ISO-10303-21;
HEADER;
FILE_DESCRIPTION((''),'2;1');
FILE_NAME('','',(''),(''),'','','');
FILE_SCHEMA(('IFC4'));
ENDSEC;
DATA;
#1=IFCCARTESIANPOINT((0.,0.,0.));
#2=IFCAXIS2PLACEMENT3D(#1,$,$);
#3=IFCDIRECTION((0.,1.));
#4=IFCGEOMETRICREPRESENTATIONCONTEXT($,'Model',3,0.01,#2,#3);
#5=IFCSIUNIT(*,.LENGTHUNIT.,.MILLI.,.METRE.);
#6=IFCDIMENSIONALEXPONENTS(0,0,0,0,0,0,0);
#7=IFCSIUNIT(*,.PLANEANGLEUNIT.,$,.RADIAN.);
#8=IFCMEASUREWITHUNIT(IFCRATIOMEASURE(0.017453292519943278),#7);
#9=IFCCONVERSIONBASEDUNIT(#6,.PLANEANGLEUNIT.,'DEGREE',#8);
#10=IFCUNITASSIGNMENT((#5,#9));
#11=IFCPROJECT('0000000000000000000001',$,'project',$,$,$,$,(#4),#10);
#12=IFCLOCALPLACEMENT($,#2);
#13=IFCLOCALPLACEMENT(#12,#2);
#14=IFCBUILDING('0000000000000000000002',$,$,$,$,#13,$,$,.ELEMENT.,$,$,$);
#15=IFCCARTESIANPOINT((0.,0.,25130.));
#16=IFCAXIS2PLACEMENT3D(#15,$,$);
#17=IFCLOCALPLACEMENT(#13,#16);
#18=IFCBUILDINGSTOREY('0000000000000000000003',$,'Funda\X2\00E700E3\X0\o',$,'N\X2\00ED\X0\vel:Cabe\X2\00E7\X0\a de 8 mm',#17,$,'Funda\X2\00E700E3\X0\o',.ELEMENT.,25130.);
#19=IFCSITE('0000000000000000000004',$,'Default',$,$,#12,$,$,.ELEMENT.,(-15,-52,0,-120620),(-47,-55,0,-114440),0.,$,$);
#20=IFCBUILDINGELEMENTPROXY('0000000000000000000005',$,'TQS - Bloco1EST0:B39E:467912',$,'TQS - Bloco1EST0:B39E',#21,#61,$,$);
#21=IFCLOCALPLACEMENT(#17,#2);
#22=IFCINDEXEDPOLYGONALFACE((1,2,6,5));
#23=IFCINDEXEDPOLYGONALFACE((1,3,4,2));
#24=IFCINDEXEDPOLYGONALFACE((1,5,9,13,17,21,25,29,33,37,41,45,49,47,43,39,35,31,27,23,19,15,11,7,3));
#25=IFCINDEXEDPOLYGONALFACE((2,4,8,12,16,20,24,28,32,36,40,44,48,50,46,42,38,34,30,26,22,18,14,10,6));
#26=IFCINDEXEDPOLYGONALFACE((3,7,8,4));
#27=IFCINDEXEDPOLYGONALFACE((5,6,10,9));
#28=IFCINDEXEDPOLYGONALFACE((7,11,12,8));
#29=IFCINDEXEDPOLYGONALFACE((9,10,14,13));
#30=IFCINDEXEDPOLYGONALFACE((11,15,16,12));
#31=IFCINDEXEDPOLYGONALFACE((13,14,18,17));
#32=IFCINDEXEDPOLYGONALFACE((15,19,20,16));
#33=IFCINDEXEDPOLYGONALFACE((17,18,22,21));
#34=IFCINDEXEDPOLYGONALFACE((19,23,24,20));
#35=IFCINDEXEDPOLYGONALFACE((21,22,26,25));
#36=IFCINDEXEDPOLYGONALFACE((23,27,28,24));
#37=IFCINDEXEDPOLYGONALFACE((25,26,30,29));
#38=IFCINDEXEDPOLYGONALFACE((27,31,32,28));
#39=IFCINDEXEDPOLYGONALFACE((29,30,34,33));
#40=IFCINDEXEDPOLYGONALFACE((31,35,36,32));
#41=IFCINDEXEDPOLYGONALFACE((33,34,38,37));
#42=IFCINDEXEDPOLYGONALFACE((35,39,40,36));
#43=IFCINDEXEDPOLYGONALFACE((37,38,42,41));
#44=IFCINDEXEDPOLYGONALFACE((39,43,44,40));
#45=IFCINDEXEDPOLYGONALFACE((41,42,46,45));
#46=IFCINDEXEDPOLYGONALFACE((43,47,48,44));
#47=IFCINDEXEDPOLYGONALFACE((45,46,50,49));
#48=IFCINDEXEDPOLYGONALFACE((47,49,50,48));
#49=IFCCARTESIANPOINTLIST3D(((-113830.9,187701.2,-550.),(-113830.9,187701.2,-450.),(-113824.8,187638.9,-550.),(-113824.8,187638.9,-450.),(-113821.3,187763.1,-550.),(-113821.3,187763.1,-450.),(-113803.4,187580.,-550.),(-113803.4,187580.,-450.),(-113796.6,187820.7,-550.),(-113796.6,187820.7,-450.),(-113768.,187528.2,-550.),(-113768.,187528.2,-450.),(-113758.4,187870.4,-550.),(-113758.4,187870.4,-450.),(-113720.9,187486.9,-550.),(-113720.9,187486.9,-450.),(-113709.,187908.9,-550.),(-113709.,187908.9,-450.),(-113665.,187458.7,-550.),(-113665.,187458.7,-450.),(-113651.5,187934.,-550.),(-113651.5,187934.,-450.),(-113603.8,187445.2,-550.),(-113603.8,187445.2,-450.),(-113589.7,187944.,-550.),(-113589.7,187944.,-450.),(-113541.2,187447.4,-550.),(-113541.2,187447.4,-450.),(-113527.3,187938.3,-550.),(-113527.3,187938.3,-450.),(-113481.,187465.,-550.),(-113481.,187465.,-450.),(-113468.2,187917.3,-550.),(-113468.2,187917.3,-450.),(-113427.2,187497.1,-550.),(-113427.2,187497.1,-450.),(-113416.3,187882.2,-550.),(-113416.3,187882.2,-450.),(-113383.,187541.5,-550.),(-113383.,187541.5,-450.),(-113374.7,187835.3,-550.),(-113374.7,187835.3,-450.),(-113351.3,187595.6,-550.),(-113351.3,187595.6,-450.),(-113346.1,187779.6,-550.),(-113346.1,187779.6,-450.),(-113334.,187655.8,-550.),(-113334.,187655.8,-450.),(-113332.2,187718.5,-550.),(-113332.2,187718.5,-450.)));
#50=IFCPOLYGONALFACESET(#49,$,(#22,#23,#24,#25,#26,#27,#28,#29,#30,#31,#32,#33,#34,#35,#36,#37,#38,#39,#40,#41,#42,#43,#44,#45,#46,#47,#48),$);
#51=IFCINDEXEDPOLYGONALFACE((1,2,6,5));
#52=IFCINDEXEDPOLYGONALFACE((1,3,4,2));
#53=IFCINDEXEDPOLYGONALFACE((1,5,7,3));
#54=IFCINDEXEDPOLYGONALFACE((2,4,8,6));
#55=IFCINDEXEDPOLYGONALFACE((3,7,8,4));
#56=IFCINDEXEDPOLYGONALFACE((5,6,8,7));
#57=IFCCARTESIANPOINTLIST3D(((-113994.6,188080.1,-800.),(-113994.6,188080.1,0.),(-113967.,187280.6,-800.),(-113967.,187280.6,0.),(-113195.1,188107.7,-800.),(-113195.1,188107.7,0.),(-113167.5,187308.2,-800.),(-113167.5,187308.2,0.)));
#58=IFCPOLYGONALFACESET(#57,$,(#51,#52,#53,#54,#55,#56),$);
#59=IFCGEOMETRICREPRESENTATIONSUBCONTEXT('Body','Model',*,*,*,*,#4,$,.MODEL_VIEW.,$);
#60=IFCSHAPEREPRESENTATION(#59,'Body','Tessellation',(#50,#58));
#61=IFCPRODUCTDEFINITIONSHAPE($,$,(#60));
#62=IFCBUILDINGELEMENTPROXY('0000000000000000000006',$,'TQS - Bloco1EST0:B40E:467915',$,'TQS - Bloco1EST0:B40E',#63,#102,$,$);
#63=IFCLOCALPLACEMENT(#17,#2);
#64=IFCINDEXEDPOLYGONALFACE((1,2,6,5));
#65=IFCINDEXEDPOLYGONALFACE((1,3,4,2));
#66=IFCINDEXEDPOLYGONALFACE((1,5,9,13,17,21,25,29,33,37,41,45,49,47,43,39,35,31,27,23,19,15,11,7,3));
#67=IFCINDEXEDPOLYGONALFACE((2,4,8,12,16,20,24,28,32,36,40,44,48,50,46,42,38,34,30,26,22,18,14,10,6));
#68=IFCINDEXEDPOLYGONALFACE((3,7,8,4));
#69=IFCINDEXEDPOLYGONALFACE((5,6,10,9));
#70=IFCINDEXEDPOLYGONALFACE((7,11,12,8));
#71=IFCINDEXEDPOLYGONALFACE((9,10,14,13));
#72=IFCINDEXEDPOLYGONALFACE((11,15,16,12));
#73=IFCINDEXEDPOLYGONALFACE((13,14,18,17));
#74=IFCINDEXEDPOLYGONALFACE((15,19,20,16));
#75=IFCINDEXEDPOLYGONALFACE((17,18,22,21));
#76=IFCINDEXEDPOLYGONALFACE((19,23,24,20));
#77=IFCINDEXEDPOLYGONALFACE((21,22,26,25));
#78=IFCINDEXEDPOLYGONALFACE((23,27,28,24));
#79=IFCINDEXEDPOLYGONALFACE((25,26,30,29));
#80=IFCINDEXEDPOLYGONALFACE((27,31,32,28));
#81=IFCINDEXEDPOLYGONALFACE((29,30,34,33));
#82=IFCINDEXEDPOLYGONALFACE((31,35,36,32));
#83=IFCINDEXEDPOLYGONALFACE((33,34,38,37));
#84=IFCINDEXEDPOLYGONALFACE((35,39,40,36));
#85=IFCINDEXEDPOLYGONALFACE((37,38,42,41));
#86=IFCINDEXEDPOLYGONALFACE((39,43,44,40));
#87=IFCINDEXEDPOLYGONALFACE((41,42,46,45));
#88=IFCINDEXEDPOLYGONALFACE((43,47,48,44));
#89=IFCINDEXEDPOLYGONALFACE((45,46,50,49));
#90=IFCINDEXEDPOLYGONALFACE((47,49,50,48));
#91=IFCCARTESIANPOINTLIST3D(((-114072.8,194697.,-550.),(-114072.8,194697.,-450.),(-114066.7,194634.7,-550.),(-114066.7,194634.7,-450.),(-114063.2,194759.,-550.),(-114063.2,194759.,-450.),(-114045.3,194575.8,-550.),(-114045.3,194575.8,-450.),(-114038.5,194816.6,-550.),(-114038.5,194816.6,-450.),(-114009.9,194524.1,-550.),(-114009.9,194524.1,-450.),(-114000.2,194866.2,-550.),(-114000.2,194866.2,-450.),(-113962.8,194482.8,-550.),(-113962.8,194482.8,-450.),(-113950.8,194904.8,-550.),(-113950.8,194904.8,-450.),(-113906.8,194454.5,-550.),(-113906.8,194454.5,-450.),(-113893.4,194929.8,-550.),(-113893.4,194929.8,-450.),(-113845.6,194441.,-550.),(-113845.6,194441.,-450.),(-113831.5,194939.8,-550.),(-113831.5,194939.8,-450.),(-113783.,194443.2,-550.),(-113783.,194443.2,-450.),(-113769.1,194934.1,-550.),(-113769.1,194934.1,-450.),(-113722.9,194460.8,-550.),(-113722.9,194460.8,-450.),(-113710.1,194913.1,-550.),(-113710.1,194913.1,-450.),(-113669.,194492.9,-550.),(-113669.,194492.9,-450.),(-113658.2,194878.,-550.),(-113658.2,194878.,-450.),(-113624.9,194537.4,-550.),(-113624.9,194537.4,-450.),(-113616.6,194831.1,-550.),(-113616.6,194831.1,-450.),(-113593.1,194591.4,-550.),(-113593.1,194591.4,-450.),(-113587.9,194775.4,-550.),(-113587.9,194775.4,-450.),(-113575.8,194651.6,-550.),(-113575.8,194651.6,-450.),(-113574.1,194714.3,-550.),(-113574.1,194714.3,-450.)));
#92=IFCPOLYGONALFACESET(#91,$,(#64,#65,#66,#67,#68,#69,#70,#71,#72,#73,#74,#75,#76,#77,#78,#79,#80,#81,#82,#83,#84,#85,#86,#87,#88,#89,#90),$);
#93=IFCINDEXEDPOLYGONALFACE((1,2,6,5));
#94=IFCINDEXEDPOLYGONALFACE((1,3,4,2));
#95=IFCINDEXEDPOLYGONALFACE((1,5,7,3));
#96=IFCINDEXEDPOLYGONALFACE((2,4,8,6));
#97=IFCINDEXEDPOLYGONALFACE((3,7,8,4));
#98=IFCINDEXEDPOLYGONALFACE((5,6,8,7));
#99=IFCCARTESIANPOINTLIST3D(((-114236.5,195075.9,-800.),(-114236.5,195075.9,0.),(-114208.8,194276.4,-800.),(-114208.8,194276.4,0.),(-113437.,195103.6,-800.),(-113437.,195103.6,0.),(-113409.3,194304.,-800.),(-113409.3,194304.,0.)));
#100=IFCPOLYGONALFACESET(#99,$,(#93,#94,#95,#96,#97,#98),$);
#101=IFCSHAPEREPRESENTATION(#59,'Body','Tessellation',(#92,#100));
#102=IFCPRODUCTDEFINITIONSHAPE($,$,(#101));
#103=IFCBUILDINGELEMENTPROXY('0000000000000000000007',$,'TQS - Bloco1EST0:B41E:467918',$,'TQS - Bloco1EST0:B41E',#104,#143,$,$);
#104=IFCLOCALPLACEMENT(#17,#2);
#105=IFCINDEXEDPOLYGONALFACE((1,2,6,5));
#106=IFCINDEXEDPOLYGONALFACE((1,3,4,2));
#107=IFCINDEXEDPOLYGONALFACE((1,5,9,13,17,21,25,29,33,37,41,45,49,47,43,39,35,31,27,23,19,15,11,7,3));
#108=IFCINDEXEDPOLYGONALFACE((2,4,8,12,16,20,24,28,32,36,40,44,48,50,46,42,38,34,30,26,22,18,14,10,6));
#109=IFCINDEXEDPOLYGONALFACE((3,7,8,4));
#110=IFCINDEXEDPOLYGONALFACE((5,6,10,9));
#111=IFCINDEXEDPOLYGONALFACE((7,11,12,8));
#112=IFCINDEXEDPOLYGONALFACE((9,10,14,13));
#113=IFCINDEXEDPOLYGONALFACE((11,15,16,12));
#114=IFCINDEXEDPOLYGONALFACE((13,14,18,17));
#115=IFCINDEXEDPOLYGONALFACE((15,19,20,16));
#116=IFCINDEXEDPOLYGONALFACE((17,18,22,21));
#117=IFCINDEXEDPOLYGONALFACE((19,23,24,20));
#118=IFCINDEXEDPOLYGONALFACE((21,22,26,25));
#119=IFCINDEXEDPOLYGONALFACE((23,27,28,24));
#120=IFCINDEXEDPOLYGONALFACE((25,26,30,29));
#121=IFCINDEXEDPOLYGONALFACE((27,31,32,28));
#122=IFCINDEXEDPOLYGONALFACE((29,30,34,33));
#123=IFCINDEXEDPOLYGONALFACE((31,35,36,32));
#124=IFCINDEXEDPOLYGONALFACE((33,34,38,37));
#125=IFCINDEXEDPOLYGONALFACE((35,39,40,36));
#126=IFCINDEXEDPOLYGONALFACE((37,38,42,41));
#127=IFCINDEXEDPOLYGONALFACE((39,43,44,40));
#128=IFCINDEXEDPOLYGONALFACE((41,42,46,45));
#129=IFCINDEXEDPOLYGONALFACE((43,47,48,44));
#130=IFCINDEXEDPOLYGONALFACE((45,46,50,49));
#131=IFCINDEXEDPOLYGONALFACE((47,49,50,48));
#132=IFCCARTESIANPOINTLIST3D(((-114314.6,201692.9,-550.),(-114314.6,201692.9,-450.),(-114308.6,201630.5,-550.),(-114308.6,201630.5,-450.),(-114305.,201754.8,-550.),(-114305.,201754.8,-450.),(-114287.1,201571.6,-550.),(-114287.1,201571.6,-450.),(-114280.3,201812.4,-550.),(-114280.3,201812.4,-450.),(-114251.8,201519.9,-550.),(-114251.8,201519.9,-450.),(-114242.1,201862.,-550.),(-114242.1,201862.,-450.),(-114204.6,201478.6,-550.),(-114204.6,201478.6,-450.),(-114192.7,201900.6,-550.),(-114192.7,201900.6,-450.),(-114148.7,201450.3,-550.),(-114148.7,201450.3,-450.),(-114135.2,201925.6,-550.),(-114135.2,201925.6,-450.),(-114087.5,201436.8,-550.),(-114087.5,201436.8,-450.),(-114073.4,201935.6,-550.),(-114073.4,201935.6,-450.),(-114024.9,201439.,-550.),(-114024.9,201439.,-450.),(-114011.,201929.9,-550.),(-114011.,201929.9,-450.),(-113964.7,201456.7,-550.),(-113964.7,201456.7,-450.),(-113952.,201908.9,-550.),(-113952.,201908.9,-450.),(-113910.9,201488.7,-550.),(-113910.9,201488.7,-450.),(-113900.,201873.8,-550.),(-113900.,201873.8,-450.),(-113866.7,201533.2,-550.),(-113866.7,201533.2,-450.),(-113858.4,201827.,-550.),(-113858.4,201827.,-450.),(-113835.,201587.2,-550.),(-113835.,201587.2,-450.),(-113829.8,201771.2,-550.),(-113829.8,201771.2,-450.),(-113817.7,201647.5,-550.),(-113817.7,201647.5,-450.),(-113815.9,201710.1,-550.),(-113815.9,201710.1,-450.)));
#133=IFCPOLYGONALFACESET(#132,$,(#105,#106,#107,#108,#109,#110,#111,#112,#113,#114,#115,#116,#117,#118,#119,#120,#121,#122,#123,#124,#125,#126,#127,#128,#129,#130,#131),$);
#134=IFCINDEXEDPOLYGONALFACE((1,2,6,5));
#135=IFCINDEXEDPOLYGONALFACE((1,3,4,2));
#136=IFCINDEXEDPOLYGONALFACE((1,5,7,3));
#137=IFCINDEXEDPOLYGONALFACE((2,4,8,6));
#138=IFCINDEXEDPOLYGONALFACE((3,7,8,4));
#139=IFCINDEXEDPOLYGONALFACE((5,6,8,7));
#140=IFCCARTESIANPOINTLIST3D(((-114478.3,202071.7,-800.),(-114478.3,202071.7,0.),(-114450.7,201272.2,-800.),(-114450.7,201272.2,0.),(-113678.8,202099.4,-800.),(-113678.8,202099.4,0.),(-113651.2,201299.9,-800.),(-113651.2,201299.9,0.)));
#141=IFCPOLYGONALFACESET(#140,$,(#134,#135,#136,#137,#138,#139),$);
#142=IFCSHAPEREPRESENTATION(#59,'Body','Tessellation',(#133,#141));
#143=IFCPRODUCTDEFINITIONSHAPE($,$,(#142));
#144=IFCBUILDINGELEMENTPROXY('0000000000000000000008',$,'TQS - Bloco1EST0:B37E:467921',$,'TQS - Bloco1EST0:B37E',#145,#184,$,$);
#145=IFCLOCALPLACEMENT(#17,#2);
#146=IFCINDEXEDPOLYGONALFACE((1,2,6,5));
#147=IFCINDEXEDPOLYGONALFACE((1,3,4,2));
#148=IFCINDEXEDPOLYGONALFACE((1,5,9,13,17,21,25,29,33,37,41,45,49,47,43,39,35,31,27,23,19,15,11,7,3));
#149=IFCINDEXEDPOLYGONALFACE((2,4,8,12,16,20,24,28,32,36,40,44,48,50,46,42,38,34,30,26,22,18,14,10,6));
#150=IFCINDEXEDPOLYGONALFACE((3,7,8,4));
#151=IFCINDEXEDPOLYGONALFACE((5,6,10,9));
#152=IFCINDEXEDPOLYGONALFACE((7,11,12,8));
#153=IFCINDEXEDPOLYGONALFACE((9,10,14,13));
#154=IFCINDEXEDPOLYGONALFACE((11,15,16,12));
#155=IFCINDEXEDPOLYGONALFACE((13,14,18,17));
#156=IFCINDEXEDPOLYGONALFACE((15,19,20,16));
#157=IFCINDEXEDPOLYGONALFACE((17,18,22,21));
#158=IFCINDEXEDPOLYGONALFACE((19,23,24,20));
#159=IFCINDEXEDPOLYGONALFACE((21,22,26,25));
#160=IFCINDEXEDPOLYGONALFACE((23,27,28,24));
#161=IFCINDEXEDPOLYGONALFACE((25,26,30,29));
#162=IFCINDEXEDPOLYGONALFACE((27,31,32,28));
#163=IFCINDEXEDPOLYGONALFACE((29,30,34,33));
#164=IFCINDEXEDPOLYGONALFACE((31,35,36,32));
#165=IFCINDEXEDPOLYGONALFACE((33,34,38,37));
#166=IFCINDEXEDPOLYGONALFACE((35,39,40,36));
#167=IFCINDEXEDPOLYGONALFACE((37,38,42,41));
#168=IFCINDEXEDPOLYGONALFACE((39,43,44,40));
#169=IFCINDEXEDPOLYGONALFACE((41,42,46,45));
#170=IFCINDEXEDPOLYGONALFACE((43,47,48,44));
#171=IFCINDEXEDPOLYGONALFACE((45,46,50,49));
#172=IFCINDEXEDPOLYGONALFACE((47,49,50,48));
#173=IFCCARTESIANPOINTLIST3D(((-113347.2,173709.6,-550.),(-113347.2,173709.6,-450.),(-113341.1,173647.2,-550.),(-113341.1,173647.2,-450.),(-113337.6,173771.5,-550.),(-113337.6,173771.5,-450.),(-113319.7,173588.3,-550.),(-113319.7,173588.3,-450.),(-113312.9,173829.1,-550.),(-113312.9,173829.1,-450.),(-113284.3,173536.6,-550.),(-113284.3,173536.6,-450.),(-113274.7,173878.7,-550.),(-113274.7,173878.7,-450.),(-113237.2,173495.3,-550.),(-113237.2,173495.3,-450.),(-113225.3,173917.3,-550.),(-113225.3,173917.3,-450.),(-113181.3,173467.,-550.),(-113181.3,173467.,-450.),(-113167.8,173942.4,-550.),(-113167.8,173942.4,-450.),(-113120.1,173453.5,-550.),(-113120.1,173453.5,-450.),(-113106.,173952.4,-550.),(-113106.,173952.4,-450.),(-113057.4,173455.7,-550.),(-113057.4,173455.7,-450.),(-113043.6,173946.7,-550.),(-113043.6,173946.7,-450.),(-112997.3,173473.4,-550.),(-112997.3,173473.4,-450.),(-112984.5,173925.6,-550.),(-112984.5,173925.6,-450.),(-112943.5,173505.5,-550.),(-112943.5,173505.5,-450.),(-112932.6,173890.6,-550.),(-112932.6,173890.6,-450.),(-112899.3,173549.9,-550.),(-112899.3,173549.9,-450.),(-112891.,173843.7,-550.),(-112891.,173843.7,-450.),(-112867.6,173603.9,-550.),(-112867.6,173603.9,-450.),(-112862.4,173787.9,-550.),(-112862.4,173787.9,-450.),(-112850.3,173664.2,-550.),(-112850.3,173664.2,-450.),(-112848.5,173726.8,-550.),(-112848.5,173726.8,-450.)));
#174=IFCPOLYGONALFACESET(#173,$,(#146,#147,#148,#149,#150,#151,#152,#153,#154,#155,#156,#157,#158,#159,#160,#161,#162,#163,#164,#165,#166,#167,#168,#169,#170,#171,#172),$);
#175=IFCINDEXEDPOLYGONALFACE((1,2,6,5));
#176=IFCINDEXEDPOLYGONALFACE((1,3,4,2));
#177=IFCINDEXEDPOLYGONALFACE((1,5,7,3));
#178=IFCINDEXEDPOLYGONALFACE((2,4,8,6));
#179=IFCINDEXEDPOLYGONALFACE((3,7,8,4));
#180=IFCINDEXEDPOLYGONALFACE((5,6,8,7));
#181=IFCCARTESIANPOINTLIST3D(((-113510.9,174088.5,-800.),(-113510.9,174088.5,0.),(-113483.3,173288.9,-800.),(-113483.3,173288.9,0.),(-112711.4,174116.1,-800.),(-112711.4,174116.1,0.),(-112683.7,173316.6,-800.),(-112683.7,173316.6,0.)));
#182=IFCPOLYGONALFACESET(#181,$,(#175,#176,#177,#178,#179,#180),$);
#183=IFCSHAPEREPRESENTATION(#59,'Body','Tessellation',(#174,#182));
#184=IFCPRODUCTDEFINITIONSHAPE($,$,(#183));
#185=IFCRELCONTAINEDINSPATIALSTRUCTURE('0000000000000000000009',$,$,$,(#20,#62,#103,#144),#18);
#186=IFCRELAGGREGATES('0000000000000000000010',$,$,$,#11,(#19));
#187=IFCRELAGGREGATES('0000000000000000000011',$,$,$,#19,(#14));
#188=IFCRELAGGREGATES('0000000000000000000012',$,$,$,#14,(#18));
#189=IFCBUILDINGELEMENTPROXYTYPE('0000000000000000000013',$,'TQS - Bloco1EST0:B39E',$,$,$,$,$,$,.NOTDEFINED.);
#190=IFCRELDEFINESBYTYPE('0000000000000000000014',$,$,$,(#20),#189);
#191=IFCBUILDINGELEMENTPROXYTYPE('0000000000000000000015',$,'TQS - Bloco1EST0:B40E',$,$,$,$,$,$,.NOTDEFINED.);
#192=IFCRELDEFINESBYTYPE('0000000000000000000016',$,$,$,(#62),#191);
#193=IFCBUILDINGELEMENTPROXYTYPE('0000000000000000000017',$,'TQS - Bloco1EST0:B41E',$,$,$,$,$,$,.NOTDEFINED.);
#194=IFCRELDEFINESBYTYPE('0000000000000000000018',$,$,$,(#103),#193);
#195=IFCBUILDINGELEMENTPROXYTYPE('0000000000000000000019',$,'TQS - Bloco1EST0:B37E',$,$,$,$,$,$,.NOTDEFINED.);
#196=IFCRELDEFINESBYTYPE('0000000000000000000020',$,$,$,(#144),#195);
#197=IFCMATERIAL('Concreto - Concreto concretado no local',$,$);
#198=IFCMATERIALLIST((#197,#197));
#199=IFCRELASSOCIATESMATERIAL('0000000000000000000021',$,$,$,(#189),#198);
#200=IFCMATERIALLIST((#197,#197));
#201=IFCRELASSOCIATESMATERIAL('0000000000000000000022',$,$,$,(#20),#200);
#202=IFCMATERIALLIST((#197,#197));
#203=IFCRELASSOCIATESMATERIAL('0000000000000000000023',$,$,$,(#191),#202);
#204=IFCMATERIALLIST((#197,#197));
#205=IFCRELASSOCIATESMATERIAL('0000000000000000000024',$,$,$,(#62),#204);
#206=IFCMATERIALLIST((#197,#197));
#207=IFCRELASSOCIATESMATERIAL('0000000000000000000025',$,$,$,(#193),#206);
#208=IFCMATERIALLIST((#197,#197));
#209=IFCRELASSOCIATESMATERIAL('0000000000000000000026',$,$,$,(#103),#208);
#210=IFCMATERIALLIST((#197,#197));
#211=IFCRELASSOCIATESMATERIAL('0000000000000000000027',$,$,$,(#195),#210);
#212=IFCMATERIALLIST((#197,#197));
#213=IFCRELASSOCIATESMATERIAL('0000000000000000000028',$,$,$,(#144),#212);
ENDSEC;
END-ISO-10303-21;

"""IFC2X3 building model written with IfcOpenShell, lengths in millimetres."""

from ifc_helpers import new_model, entity, si_unit, converted_unit, direction, frame, frame_2d, origin, origin_2d_with_axis, place, context, subcontext, project, spatial, rectangle, circle, extrude, source, transform, mapped, material, material_list, type_object, type_shapes, element, save


model = new_model("IFC2X3")

# Units and contexts
model_context = context("Model", 3, precision=0.01, world=origin(), true_north=direction((0.0, 1.0)))
body_context = subcontext(model_context, "Body", "Model", "MODEL_VIEW")
ifc_project = project(units=[si_unit("LENGTHUNIT", "METRE", prefix="MILLI"), converted_unit("PLANEANGLEUNIT", "DEGREE", entity("IfcRatioMeasure", 0.017453292519943278), si_unit("PLANEANGLEUNIT", "RADIAN"), dimensions=[0, 0, 0, 0, 0, 0, 0])], contexts=[model_context])

# Site, building, storey
site_placement = place(None, origin())
site = spatial("IfcSite", under=ifc_project, at=site_placement, Name="Default", CompositionType="ELEMENT", RefLatitude=(-15, -52, 0, -120620), RefLongitude=(-47, -55, 0, -114440), RefElevation=0.0)
building_placement = place(site_placement, origin())
building = spatial("IfcBuilding", under=site, at=building_placement, CompositionType="ELEMENT")
storey_placement = place(building_placement, frame((0.0, 0.0, 25130.0)))
storey = spatial("IfcBuildingStorey", under=building, at=storey_placement, Name="Fundação", ObjectType="Nível:Cabeça de 8 mm", LongName="Fundação", CompositionType="ELEMENT", Elevation=25130.0)

# Building element proxies
ifc_material_1 = material(Name="Concreto - Concreto concretado no local")
ifc_material_list_1 = material_list([ifc_material_1, ifc_material_1])
ifc_material_list_2 = material_list([ifc_material_1, ifc_material_1])
building_element_proxy_type_1 = type_object("IfcBuildingElementProxyType", Name="TQS - Bloco1EST0:B39E", PredefinedType="NOTDEFINED", material=ifc_material_list_2)
shared_shape_1 = source(origin(), body_context, "Body", "SweptSolid", [
    extrude(circle(Radius=250.0, at=frame_2d((0.0, 0.0), x_axis=(1.0, 0.0))), frame((0.0, 0.0, -550.0)), (0.0, 0.0, 1.0), 100.0),
    extrude(rectangle(XDim=800.0, YDim=800.0, at=origin_2d_with_axis()), frame((0.0, 0.0, -800.0), z_axis=(0.0, 0.0, 1.0), x_axis=(-1.0, 0.0, 0.0)), (0.0, 0.0, 1.0), 800.0),
])
type_shapes(building_element_proxy_type_1, [shared_shape_1])
proxy_1_placement = place(storey_placement, frame((-113581.0, 187694.2, 0.0), z_axis=(0.0, 0.0, 1.0), x_axis=(-0.034551, 0.999403, 0.0)))
element("IfcBuildingElementProxy", 1, at=proxy_1_placement, inside=storey, type_object=building_element_proxy_type_1, material=ifc_material_list_1, Name="TQS - Bloco1EST0:B39E:467912", ObjectType="TQS - Bloco1EST0:B39E", context=body_context, shape_type="MappedRepresentation", body=[
    mapped(shared_shape_1, transform((0.0, 0.0, 0.0), scale=1.0)),
])
ifc_material_list_3 = material_list([ifc_material_1, ifc_material_1])
ifc_material_list_4 = material_list([ifc_material_1, ifc_material_1])
building_element_proxy_type_2 = type_object("IfcBuildingElementProxyType", Name="TQS - Bloco1EST0:B40E", PredefinedType="NOTDEFINED", material=ifc_material_list_4)
shared_shape_2 = source(origin(), body_context, "Body", "SweptSolid", [
    extrude(circle(Radius=250.0, at=frame_2d((0.0, 0.0), x_axis=(1.0, 0.0))), frame((0.0, 0.0, -550.0)), (0.0, 0.0, 1.0), 100.0),
    extrude(rectangle(XDim=800.0, YDim=800.0, at=origin_2d_with_axis()), frame((0.0, 0.0, -800.0), z_axis=(0.0, 0.0, 1.0), x_axis=(-1.0, 0.0, 0.0)), (0.0, 0.0, 1.0), 800.0),
])
type_shapes(building_element_proxy_type_2, [shared_shape_2])
proxy_2_placement = place(storey_placement, frame((-113822.9, 194690.0, 0.0), z_axis=(0.0, 0.0, 1.0), x_axis=(-0.034551, 0.999403, 0.0)))
element("IfcBuildingElementProxy", 2, at=proxy_2_placement, inside=storey, type_object=building_element_proxy_type_2, material=ifc_material_list_3, Name="TQS - Bloco1EST0:B40E:467915", ObjectType="TQS - Bloco1EST0:B40E", context=body_context, shape_type="MappedRepresentation", body=[
    mapped(shared_shape_2, transform((0.0, 0.0, 0.0), scale=1.0)),
])
ifc_material_list_5 = material_list([ifc_material_1, ifc_material_1])
ifc_material_list_6 = material_list([ifc_material_1, ifc_material_1])
building_element_proxy_type_3 = type_object("IfcBuildingElementProxyType", Name="TQS - Bloco1EST0:B41E", PredefinedType="NOTDEFINED", material=ifc_material_list_6)
shared_shape_3 = source(origin(), body_context, "Body", "SweptSolid", [
    extrude(circle(Radius=250.0, at=frame_2d((0.0, 0.0), x_axis=(1.0, 0.0))), frame((0.0, 0.0, -550.0)), (0.0, 0.0, 1.0), 100.0),
    extrude(rectangle(XDim=800.0, YDim=800.0, at=origin_2d_with_axis()), frame((0.0, 0.0, -800.0), z_axis=(0.0, 0.0, 1.0), x_axis=(-1.0, 0.0, 0.0)), (0.0, 0.0, 1.0), 800.0),
])
type_shapes(building_element_proxy_type_3, [shared_shape_3])
proxy_3_placement = place(storey_placement, frame((-114064.7, 201685.8, 0.0), z_axis=(0.0, 0.0, 1.0), x_axis=(-0.034551, 0.999403, 0.0)))
element("IfcBuildingElementProxy", 3, at=proxy_3_placement, inside=storey, type_object=building_element_proxy_type_3, material=ifc_material_list_5, Name="TQS - Bloco1EST0:B41E:467918", ObjectType="TQS - Bloco1EST0:B41E", context=body_context, shape_type="MappedRepresentation", body=[
    mapped(shared_shape_3, transform((0.0, 0.0, 0.0), scale=1.0)),
])
ifc_material_list_7 = material_list([ifc_material_1, ifc_material_1])
ifc_material_list_8 = material_list([ifc_material_1, ifc_material_1])
building_element_proxy_type_4 = type_object("IfcBuildingElementProxyType", Name="TQS - Bloco1EST0:B37E", PredefinedType="NOTDEFINED", material=ifc_material_list_8)
shared_shape_4 = source(origin(), body_context, "Body", "SweptSolid", [
    extrude(circle(Radius=250.0, at=frame_2d((0.0, 0.0), x_axis=(1.0, 0.0))), frame((0.0, 0.0, -550.0)), (0.0, 0.0, 1.0), 100.0),
    extrude(rectangle(XDim=800.0, YDim=800.0, at=origin_2d_with_axis()), frame((0.0, 0.0, -800.0), z_axis=(0.0, 0.0, 1.0), x_axis=(-1.0, 0.0, 0.0)), (0.0, 0.0, 1.0), 800.0),
])
type_shapes(building_element_proxy_type_4, [shared_shape_4])
proxy_4_placement = place(storey_placement, frame((-113097.3, 173702.5, 0.0), z_axis=(0.0, 0.0, 1.0), x_axis=(-0.034551, 0.999403, 0.0)))
element("IfcBuildingElementProxy", 4, at=proxy_4_placement, inside=storey, type_object=building_element_proxy_type_4, material=ifc_material_list_7, Name="TQS - Bloco1EST0:B37E:467921", ObjectType="TQS - Bloco1EST0:B37E", context=body_context, shape_type="MappedRepresentation", body=[
    mapped(shared_shape_4, transform((0.0, 0.0, 0.0), scale=1.0)),
])

save(model, "model.ifc")
